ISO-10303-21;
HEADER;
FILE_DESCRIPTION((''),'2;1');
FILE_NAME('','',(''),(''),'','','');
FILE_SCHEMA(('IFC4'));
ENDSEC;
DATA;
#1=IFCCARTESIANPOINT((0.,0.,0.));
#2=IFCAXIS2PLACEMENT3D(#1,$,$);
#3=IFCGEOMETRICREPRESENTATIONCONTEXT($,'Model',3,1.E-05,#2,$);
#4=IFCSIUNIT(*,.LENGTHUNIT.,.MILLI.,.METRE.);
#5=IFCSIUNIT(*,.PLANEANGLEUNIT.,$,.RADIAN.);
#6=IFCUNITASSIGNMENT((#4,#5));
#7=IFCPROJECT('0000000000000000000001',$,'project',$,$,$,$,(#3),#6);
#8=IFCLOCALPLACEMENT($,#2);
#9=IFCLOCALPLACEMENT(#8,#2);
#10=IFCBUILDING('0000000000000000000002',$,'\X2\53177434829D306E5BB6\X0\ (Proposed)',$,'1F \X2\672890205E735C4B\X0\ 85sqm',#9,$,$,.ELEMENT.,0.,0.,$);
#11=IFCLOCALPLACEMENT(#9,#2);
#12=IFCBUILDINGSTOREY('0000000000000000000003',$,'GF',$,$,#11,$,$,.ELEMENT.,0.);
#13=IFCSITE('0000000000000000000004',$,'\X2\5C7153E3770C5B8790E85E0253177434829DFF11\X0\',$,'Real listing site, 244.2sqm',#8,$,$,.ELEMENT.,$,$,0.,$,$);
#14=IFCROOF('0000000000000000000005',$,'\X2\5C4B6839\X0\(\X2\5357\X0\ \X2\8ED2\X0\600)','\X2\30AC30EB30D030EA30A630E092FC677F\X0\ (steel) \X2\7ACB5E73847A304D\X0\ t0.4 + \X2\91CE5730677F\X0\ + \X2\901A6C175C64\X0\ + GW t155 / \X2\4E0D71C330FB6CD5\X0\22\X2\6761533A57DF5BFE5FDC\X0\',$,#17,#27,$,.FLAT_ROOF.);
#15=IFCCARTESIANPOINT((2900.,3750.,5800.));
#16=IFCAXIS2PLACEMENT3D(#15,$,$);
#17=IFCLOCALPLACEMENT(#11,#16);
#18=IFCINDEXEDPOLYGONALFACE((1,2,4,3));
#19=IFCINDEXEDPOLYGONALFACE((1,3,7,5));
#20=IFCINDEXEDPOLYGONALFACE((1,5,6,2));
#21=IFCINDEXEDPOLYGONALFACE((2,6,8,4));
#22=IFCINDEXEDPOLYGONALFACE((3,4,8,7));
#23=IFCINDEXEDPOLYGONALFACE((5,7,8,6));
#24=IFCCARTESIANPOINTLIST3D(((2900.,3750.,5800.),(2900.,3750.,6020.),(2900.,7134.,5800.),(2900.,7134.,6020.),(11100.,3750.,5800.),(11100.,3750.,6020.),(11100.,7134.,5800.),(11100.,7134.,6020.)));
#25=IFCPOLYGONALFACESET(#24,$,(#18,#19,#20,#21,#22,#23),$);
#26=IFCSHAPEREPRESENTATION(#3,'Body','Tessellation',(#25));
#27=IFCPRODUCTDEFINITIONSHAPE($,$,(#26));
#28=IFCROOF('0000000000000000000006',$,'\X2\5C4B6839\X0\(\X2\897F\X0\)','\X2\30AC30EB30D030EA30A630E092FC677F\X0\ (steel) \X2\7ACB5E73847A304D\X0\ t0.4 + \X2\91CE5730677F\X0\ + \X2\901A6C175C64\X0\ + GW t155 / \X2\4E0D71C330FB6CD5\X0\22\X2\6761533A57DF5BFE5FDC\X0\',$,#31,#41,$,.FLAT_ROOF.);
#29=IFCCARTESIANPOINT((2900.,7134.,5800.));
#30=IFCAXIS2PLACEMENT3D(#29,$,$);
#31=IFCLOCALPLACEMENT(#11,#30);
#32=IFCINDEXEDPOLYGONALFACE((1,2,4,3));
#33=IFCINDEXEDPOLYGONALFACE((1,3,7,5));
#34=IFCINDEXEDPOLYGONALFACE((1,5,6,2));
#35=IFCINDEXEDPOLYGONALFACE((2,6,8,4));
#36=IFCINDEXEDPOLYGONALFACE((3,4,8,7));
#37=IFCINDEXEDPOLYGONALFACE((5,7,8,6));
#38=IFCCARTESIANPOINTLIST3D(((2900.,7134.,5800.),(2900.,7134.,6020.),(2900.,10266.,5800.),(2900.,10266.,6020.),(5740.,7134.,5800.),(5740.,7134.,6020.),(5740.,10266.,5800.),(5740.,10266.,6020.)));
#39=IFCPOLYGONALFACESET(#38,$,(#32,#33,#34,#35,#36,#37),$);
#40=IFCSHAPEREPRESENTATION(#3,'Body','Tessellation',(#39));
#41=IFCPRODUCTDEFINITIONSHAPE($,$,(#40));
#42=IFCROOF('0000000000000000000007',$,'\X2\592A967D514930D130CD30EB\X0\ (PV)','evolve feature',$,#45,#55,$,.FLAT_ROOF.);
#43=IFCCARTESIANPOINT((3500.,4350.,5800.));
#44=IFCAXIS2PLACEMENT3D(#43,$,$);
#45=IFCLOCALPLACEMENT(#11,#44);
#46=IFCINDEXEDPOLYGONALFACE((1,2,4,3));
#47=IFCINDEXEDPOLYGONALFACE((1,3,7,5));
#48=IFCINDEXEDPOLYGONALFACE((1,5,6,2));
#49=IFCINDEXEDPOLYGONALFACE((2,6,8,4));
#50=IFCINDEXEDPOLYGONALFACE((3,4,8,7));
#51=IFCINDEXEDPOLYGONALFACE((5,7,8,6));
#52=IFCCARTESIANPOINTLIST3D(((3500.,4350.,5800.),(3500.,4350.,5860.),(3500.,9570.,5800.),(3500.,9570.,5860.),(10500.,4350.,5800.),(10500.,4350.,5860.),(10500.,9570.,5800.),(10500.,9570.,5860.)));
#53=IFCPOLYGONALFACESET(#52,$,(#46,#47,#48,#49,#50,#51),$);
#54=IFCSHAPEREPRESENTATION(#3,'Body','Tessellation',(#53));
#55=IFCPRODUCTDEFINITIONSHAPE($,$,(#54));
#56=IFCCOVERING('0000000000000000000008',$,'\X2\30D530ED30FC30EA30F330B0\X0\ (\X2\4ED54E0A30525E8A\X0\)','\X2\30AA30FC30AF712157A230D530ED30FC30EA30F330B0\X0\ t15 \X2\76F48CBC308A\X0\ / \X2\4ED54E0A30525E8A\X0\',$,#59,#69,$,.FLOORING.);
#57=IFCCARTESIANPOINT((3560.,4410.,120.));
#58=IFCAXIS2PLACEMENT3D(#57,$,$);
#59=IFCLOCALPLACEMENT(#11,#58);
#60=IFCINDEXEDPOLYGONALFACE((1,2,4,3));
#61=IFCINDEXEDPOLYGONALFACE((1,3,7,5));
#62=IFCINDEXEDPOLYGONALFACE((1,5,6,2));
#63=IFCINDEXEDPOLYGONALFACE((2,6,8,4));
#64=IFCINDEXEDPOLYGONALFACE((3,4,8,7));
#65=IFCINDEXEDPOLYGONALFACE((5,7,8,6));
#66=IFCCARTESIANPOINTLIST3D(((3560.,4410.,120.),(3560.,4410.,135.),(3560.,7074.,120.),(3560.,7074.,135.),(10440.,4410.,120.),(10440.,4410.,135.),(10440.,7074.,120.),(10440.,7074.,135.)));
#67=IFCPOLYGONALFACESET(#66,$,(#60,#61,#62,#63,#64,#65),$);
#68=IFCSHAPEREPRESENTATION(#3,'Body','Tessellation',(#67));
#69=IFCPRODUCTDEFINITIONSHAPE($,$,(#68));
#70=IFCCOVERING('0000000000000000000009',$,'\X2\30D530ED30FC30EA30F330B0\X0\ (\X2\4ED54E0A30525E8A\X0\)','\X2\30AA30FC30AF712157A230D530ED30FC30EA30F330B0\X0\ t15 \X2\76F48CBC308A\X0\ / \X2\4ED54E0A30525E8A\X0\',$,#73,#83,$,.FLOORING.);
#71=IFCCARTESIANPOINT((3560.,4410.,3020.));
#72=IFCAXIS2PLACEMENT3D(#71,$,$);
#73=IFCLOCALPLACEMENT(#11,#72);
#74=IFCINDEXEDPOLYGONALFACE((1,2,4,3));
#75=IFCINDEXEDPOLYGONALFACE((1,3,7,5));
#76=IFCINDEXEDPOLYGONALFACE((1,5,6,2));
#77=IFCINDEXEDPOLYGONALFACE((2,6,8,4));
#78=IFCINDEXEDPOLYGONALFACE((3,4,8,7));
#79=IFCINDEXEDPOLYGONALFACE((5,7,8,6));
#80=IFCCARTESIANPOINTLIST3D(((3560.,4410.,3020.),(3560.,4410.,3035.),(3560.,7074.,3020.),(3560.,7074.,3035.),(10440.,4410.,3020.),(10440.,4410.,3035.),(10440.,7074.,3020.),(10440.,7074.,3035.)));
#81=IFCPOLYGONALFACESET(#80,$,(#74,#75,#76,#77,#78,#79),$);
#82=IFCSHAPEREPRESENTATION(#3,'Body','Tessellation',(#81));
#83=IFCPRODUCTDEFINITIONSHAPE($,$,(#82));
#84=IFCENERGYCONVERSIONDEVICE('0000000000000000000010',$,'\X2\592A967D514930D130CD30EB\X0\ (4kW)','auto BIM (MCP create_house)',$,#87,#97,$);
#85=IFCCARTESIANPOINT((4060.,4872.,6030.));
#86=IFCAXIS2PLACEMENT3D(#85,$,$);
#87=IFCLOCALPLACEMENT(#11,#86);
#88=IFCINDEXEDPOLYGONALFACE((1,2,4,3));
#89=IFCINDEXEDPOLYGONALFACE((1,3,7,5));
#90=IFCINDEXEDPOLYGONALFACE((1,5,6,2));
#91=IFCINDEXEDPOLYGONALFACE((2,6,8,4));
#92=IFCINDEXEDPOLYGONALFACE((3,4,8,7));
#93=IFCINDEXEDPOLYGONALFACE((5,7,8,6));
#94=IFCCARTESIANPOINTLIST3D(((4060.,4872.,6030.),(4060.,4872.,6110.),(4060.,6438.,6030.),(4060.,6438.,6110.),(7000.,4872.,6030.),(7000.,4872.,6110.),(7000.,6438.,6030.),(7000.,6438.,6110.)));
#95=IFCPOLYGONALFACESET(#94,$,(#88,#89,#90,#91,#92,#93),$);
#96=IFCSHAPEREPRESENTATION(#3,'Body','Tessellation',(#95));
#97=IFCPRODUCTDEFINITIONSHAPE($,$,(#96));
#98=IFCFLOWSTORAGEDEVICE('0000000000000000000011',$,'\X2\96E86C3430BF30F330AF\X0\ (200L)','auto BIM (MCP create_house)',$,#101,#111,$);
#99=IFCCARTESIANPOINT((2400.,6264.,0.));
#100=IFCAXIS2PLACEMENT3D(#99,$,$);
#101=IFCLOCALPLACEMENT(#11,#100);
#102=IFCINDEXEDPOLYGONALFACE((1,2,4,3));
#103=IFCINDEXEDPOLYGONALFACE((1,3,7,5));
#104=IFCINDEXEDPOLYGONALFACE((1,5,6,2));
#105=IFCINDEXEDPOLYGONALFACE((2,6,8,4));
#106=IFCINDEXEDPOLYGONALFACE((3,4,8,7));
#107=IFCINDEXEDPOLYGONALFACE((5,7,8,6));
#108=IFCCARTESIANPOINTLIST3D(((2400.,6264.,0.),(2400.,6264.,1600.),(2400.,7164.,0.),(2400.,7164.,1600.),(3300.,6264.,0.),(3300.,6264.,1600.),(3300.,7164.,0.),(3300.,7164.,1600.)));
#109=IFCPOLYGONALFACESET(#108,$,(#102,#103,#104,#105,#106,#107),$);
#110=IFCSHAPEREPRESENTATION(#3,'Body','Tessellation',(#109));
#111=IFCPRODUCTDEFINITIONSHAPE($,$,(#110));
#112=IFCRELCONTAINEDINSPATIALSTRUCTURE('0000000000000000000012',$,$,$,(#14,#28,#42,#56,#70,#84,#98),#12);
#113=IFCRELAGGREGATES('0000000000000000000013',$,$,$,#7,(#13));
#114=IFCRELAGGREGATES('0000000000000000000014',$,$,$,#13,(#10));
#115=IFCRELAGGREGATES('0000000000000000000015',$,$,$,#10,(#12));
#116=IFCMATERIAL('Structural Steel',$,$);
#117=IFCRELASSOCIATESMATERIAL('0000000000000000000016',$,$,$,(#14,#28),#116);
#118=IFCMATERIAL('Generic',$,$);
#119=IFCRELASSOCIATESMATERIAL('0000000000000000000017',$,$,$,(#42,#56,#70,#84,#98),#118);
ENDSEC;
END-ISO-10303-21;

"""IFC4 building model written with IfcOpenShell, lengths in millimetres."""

from ifc_helpers import new_model, si_unit, frame, frame_2d, origin, place, context, project, spatial, rectangle, extrude, material, element, save


model = new_model("IFC4")

# Units and contexts
model_context = context("Model", 3, precision=1e-05, world=origin())
ifc_project = project(units=[si_unit("LENGTHUNIT", "METRE", prefix="MILLI"), si_unit("PLANEANGLEUNIT", "RADIAN")], contexts=[model_context])

# Site, building, storey
site_placement = place(None, origin())
site = spatial("IfcSite", under=ifc_project, at=site_placement, Name="山口県宇部市北琴芝１", ObjectType="Real listing site, 244.2sqm", CompositionType="ELEMENT", RefElevation=0.0)
building_placement = place(site_placement, origin())
building = spatial("IfcBuilding", under=site, at=building_placement, Name="北琴芝の家 (Proposed)", ObjectType="1F 木造平屋 85sqm", CompositionType="ELEMENT", ElevationOfRefHeight=0.0, ElevationOfTerrain=0.0)
storey_placement = place(building_placement, origin())
storey = spatial("IfcBuildingStorey", under=building, at=storey_placement, Name="GF", CompositionType="ELEMENT", Elevation=0.0)

# Shared definitions
ifc_material_1 = material(Name="Generic")

# Roofs
ifc_material_2 = material(Name="Structural Steel")
roof_1_placement = place(storey_placement, frame((2900.0, 3750.0, 5800.0)))
element("IfcRoof", 1, at=roof_1_placement, inside=storey, material=ifc_material_2, Name="屋根(南 軒600)", Description="ガルバリウム鋼板 (steel) 立平葺き t0.4 + 野地板 + 通気層 + GW t155 / 不燃・法22条区域対応", PredefinedType="FLAT_ROOF", context=model_context, shape_type="SweptSolid", body=[
    extrude(rectangle(XDim=8200.0, YDim=3384.0, at=frame_2d((4100.0, 1692.0))), frame((2900.0, 3750.0, 5800.0)), (0.0, 0.0, 1.0), 220.0),
])
roof_2_placement = place(storey_placement, frame((2900.0, 7134.0, 5800.0)))
element("IfcRoof", 2, at=roof_2_placement, inside=storey, material=ifc_material_2, Name="屋根(西)", Description="ガルバリウム鋼板 (steel) 立平葺き t0.4 + 野地板 + 通気層 + GW t155 / 不燃・法22条区域対応", PredefinedType="FLAT_ROOF", context=model_context, shape_type="SweptSolid", body=[
    extrude(rectangle(XDim=2840.0, YDim=3132.0, at=frame_2d((1420.0, 1566.0))), frame((2900.0, 7134.0, 5800.0)), (0.0, 0.0, 1.0), 220.0),
])
roof_3_placement = place(storey_placement, frame((3500.0, 4350.0, 5800.0)))
element("IfcRoof", 3, at=roof_3_placement, inside=storey, material=ifc_material_1, Name="太陽光パネル (PV)", Description="evolve feature", PredefinedType="FLAT_ROOF", context=model_context, shape_type="SweptSolid", body=[
    extrude(rectangle(XDim=7000.0, YDim=5220.0, at=frame_2d((3500.0, 2610.0))), frame((3500.0, 4350.0, 5800.0)), (0.0, 0.0, 1.0), 60.0),
])

# Coverings
covering_1_placement = place(storey_placement, frame((3560.0, 4410.0, 120.0)))
element("IfcCovering", 4, at=covering_1_placement, inside=storey, material=ifc_material_1, Name="フローリング (仕上げ床)", Description="オーク無垢フローリング t15 直貼り / 仕上げ床", PredefinedType="FLOORING", context=model_context, shape_type="SweptSolid", body=[
    extrude(rectangle(XDim=6880.0, YDim=2664.0, at=frame_2d((3440.0, 1332.0))), frame((3560.0, 4410.0, 120.0)), (0.0, 0.0, 1.0), 15.0),
])
covering_2_placement = place(storey_placement, frame((3560.0, 4410.0, 3020.0)))
element("IfcCovering", 5, at=covering_2_placement, inside=storey, material=ifc_material_1, Name="フローリング (仕上げ床)", Description="オーク無垢フローリング t15 直貼り / 仕上げ床", PredefinedType="FLOORING", context=model_context, shape_type="SweptSolid", body=[
    extrude(rectangle(XDim=6880.0, YDim=2664.0, at=frame_2d((3440.0, 1332.0))), frame((3560.0, 4410.0, 3020.0)), (0.0, 0.0, 1.0), 15.0),
])

# Energy conversion device
energy_conversion_device_placement = place(storey_placement, frame((4060.0, 4872.0, 6030.0)))
element("IfcEnergyConversionDevice", 6, at=energy_conversion_device_placement, inside=storey, material=ifc_material_1, Name="太陽光パネル (4kW)", Description="auto BIM (MCP create_house)", context=model_context, shape_type="SweptSolid", body=[
    extrude(rectangle(XDim=2940.0, YDim=1566.0, at=frame_2d((1470.0, 783.0))), frame((4060.0, 4872.0, 6030.0)), (0.0, 0.0, 1.0), 80.0),
])

# Flow storage device
flow_storage_device_placement = place(storey_placement, frame((2400.0, 6264.0, 0.0)))
element("IfcFlowStorageDevice", 7, at=flow_storage_device_placement, inside=storey, material=ifc_material_1, Name="雨水タンク (200L)", Description="auto BIM (MCP create_house)", context=model_context, shape_type="SweptSolid", body=[
    extrude(rectangle(XDim=900.0, YDim=900.0, at=frame_2d((450.0, 450.0))), frame((2400.0, 6264.0, 0.0)), (0.0, 0.0, 1.0), 1600.0),
])

save(model, "model.ifc")
